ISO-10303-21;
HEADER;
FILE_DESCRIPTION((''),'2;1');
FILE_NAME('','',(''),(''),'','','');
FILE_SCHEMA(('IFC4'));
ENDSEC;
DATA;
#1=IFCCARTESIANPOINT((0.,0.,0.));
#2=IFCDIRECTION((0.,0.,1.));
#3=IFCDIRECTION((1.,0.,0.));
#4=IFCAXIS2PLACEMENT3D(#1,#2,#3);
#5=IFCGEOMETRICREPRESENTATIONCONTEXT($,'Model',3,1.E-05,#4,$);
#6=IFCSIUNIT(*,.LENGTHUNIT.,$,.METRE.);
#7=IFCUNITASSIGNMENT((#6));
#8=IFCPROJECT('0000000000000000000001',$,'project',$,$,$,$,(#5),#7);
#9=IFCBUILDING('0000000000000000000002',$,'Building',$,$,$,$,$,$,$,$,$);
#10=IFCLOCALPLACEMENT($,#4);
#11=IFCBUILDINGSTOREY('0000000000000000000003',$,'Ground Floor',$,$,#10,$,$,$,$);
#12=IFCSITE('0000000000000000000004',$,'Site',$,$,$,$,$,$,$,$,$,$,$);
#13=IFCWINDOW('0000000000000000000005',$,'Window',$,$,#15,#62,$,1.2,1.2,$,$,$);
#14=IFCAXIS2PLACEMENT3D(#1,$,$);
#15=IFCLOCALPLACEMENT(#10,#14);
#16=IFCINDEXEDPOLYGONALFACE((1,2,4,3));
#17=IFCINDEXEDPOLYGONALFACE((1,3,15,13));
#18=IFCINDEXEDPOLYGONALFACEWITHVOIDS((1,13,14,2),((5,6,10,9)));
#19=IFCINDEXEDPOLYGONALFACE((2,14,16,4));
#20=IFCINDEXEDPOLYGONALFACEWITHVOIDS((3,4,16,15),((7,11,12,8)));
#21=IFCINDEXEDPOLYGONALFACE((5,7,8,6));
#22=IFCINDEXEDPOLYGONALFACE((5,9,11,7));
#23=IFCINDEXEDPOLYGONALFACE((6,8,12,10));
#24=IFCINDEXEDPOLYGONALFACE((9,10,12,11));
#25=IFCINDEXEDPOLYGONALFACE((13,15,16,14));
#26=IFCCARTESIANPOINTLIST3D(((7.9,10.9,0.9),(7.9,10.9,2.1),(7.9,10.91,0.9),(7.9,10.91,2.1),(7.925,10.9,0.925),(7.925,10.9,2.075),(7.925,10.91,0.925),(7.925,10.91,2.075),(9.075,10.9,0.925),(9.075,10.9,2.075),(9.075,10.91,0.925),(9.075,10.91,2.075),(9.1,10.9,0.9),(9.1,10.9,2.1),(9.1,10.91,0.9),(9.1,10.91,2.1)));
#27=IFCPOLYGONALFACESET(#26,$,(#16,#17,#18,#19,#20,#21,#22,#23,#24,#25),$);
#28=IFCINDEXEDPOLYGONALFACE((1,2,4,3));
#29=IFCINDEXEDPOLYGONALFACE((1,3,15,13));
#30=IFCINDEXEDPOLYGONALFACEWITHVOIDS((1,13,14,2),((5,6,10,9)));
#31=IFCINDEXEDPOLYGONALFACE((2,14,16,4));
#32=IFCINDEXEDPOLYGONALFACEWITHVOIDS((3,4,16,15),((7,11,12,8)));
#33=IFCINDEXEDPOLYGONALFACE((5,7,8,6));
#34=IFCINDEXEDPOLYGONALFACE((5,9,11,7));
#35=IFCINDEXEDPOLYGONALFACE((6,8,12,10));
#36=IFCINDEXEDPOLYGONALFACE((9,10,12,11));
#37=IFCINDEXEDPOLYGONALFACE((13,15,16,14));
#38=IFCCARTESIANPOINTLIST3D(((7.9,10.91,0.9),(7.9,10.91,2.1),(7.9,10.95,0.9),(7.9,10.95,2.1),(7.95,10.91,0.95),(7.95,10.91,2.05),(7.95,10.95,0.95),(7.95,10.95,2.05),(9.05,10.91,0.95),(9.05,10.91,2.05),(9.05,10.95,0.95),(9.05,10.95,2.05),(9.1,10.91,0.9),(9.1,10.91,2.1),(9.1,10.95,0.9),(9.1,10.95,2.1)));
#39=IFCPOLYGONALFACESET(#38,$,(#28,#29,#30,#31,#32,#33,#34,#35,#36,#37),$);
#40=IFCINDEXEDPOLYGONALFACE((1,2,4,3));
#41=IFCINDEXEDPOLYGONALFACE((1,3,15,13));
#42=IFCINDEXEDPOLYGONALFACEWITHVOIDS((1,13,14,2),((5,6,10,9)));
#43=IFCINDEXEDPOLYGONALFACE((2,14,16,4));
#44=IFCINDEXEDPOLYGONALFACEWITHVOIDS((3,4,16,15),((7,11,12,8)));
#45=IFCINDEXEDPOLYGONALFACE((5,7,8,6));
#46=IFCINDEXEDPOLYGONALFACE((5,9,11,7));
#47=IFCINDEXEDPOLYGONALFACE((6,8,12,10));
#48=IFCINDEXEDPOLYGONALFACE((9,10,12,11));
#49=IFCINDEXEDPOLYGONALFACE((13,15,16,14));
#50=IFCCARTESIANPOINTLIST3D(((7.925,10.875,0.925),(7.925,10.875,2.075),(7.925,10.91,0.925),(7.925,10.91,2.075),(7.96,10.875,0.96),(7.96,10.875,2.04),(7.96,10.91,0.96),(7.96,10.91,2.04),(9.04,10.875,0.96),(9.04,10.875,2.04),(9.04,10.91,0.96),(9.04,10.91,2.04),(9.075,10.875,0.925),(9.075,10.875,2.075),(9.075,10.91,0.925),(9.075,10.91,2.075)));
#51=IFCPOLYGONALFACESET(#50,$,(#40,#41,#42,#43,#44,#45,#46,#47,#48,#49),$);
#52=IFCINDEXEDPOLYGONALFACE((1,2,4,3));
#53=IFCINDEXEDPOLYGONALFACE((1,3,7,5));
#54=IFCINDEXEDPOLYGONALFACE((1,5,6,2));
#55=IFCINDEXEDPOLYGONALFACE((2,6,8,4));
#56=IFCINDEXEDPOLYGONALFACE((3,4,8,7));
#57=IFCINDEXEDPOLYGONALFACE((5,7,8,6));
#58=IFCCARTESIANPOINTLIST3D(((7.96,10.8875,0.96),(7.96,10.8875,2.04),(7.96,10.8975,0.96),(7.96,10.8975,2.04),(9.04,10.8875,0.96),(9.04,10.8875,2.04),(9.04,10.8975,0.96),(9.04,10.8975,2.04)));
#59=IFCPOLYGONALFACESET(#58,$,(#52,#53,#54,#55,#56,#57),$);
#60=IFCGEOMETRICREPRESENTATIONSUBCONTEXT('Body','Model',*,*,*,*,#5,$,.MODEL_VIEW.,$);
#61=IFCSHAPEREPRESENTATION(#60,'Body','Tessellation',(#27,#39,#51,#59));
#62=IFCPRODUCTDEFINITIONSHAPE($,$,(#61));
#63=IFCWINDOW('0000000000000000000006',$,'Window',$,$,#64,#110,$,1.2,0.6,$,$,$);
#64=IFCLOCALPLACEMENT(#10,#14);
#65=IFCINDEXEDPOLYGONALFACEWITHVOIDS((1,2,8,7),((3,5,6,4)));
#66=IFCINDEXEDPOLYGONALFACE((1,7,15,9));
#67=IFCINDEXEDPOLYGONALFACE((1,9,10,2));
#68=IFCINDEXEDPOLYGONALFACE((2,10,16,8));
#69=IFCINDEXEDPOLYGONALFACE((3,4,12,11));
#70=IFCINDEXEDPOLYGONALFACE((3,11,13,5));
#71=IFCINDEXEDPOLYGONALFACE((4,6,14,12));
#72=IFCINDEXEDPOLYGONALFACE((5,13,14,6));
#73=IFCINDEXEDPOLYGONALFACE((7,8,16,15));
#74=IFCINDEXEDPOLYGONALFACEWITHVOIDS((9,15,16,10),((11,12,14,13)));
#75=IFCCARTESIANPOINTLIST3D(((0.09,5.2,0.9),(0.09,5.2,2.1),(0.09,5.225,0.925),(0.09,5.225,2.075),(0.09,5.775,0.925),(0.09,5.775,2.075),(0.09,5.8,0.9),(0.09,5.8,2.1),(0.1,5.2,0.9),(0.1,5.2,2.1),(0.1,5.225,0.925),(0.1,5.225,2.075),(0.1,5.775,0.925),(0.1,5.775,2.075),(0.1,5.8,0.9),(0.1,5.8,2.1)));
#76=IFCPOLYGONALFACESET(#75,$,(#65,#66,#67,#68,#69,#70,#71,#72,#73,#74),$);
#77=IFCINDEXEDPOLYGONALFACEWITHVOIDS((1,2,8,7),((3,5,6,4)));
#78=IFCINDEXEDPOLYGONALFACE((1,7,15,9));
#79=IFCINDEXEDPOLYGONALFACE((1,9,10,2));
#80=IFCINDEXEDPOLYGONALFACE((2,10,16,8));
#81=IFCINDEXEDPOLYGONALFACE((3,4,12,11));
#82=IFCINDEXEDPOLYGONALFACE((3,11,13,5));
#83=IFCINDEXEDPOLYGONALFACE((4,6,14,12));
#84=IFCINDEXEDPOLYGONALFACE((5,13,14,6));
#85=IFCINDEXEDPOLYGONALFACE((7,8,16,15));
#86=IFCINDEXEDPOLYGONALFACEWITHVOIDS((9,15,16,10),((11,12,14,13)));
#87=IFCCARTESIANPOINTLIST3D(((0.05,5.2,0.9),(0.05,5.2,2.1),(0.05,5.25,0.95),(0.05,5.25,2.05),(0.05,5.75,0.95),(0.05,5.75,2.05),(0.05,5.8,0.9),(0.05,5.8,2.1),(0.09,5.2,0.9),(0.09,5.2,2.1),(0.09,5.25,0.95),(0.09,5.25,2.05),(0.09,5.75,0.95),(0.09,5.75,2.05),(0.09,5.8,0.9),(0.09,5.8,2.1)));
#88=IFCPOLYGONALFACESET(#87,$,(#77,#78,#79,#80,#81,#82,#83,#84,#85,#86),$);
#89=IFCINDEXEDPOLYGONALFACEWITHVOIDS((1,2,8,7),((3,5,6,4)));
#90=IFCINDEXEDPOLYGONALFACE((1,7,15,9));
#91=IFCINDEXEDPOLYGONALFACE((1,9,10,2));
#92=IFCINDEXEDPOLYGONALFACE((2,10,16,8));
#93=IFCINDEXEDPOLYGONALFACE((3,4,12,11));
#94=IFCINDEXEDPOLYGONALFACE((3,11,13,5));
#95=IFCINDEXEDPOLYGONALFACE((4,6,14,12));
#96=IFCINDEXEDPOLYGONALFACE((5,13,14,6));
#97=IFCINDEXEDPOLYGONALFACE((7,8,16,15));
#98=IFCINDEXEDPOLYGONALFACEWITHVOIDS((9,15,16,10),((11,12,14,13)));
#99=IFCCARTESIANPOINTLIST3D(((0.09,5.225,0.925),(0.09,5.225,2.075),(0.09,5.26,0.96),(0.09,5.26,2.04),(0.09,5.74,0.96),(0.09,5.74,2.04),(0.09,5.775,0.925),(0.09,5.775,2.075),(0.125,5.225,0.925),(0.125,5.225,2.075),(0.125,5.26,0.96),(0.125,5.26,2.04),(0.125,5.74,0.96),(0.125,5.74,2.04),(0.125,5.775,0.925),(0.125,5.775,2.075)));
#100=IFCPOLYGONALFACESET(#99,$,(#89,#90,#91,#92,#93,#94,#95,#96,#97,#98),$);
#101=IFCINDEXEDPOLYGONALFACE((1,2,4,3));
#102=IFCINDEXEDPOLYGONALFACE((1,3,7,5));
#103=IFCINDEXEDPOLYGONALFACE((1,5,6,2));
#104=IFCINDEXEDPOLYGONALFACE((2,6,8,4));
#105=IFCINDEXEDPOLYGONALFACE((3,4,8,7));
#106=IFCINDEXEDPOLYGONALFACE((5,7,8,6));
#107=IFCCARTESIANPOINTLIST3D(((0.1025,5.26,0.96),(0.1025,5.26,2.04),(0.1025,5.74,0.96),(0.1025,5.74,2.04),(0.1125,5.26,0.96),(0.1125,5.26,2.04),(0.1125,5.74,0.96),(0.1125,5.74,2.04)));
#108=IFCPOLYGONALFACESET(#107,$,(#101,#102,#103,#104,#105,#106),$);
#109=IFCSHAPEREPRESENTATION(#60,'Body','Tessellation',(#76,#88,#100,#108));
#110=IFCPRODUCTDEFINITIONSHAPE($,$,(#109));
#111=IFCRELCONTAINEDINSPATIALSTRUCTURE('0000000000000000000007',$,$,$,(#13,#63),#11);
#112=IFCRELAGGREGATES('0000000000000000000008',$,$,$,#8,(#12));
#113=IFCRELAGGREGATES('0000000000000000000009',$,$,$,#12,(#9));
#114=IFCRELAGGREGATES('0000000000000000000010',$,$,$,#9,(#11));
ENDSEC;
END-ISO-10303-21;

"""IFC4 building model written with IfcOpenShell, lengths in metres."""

from ifc_helpers import new_model, si_unit, frame, origin_with_axes, place, context, subcontext, project, spatial, line, indexed_curve, outline, extrude, element, save


model = new_model("IFC4")

# Units and contexts
model_context = context("Model", 3, precision=1e-05, world=origin_with_axes())
body_context = subcontext(model_context, "Body", "Model", "MODEL_VIEW")
ifc_project = project(units=[si_unit("LENGTHUNIT", "METRE")], contexts=[model_context])

# Site, building, storey
site = spatial("IfcSite", under=ifc_project, Name="Site")
building = spatial("IfcBuilding", under=site, Name="Building")
storey_placement = place(None, origin_with_axes())
storey = spatial("IfcBuildingStorey", under=building, at=storey_placement, Name="Ground Floor")

# Windows
window_1_placement = place(storey_placement, frame((9.1, 11.0, 0.9), z_axis=(0.0, 0.0, 1.0), x_axis=(-1.0, 0.0, 0.0)))
element("IfcWindow", 1, at=window_1_placement, inside=storey, Name="Window", OverallHeight=1.2, OverallWidth=1.2, context=body_context, shape_type="SweptSolid", body=[
    extrude(outline(indexed_curve([(0.0, 0.0), (1.2, 0.0), (1.2, 1.2), (0.0, 1.2)], segments=[line(1, 2, 3, 4, 1)]), holes=[indexed_curve([(0.025, 0.025), (1.175, 0.025), (1.175, 1.175), (0.025, 1.175)], segments=[line(1, 2, 3, 4, 1)])]), frame((0.0, 0.09, 0.0), z_axis=(0.0, -1.0, 0.0), x_axis=(1.0, 0.0, 0.0)), (0.0, 0.0, -1.0), 0.01),
    extrude(outline(indexed_curve([(0.0, 0.0), (1.2, 0.0), (1.2, 1.2), (0.0, 1.2)], segments=[line(1, 2, 3, 4, 1)]), holes=[indexed_curve([(0.05, 0.05), (1.15, 0.05), (1.15, 1.15), (0.05, 1.15)], segments=[line(1, 2, 3, 4, 1)])]), frame((0.0, 0.05, 0.0), z_axis=(0.0, -1.0, 0.0), x_axis=(1.0, 0.0, 0.0)), (0.0, 0.0, -1.0), 0.04),
    extrude(outline(indexed_curve([(0.0, 0.0), (1.15, 0.0), (1.15, 1.15), (0.0, 1.15)], segments=[line(1, 2, 3, 4, 1)]), holes=[indexed_curve([(0.035, 0.035), (1.115, 0.035), (1.115, 1.115), (0.035, 1.115)], segments=[line(1, 2, 3, 4, 1)])]), frame((0.025, 0.09, 0.025), z_axis=(0.0, -1.0, 0.0), x_axis=(1.0, 0.0, 0.0)), (0.0, 0.0, -1.0), 0.035),
    extrude(outline(indexed_curve([(0.035, 0.035), (1.115, 0.035), (1.115, 1.115), (0.035, 1.115)], segments=[line(1, 2, 3, 4, 1)])), frame((0.025, 0.1025, 0.025), z_axis=(0.0, -1.0, 0.0), x_axis=(1.0, 0.0, 0.0)), (0.0, 0.0, -1.0), 0.01),
])
window_2_placement = place(storey_placement, frame((0.0, 5.8, 0.9), z_axis=(0.0, 0.0, 1.0), x_axis=(0.0, -1.0, 0.0)))
element("IfcWindow", 2, at=window_2_placement, inside=storey, Name="Window", OverallHeight=1.2, OverallWidth=0.6, context=body_context, shape_type="SweptSolid", body=[
    extrude(outline(indexed_curve([(0.0, 0.0), (0.6, 0.0), (0.6, 1.2), (0.0, 1.2)], segments=[line(1, 2, 3, 4, 1)]), holes=[indexed_curve([(0.025, 0.025), (0.575, 0.025), (0.575, 1.175), (0.025, 1.175)], segments=[line(1, 2, 3, 4, 1)])]), frame((0.0, 0.09, 0.0), z_axis=(0.0, -1.0, 0.0), x_axis=(1.0, 0.0, 0.0)), (0.0, 0.0, -1.0), 0.01),
    extrude(outline(indexed_curve([(0.0, 0.0), (0.6, 0.0), (0.6, 1.2), (0.0, 1.2)], segments=[line(1, 2, 3, 4, 1)]), holes=[indexed_curve([(0.05, 0.05), (0.55, 0.05), (0.55, 1.15), (0.05, 1.15)], segments=[line(1, 2, 3, 4, 1)])]), frame((0.0, 0.05, 0.0), z_axis=(0.0, -1.0, 0.0), x_axis=(1.0, 0.0, 0.0)), (0.0, 0.0, -1.0), 0.04),
    extrude(outline(indexed_curve([(0.0, 0.0), (0.55, 0.0), (0.55, 1.15), (0.0, 1.15)], segments=[line(1, 2, 3, 4, 1)]), holes=[indexed_curve([(0.035, 0.035), (0.515, 0.035), (0.515, 1.115), (0.035, 1.115)], segments=[line(1, 2, 3, 4, 1)])]), frame((0.025, 0.09, 0.025), z_axis=(0.0, -1.0, 0.0), x_axis=(1.0, 0.0, 0.0)), (0.0, 0.0, -1.0), 0.035),
    extrude(outline(indexed_curve([(0.035, 0.035), (0.515, 0.035), (0.515, 1.115), (0.035, 1.115)], segments=[line(1, 2, 3, 4, 1)])), frame((0.025, 0.1025, 0.025), z_axis=(0.0, -1.0, 0.0), x_axis=(1.0, 0.0, 0.0)), (0.0, 0.0, -1.0), 0.01),
])

save(model, "model.ifc")
